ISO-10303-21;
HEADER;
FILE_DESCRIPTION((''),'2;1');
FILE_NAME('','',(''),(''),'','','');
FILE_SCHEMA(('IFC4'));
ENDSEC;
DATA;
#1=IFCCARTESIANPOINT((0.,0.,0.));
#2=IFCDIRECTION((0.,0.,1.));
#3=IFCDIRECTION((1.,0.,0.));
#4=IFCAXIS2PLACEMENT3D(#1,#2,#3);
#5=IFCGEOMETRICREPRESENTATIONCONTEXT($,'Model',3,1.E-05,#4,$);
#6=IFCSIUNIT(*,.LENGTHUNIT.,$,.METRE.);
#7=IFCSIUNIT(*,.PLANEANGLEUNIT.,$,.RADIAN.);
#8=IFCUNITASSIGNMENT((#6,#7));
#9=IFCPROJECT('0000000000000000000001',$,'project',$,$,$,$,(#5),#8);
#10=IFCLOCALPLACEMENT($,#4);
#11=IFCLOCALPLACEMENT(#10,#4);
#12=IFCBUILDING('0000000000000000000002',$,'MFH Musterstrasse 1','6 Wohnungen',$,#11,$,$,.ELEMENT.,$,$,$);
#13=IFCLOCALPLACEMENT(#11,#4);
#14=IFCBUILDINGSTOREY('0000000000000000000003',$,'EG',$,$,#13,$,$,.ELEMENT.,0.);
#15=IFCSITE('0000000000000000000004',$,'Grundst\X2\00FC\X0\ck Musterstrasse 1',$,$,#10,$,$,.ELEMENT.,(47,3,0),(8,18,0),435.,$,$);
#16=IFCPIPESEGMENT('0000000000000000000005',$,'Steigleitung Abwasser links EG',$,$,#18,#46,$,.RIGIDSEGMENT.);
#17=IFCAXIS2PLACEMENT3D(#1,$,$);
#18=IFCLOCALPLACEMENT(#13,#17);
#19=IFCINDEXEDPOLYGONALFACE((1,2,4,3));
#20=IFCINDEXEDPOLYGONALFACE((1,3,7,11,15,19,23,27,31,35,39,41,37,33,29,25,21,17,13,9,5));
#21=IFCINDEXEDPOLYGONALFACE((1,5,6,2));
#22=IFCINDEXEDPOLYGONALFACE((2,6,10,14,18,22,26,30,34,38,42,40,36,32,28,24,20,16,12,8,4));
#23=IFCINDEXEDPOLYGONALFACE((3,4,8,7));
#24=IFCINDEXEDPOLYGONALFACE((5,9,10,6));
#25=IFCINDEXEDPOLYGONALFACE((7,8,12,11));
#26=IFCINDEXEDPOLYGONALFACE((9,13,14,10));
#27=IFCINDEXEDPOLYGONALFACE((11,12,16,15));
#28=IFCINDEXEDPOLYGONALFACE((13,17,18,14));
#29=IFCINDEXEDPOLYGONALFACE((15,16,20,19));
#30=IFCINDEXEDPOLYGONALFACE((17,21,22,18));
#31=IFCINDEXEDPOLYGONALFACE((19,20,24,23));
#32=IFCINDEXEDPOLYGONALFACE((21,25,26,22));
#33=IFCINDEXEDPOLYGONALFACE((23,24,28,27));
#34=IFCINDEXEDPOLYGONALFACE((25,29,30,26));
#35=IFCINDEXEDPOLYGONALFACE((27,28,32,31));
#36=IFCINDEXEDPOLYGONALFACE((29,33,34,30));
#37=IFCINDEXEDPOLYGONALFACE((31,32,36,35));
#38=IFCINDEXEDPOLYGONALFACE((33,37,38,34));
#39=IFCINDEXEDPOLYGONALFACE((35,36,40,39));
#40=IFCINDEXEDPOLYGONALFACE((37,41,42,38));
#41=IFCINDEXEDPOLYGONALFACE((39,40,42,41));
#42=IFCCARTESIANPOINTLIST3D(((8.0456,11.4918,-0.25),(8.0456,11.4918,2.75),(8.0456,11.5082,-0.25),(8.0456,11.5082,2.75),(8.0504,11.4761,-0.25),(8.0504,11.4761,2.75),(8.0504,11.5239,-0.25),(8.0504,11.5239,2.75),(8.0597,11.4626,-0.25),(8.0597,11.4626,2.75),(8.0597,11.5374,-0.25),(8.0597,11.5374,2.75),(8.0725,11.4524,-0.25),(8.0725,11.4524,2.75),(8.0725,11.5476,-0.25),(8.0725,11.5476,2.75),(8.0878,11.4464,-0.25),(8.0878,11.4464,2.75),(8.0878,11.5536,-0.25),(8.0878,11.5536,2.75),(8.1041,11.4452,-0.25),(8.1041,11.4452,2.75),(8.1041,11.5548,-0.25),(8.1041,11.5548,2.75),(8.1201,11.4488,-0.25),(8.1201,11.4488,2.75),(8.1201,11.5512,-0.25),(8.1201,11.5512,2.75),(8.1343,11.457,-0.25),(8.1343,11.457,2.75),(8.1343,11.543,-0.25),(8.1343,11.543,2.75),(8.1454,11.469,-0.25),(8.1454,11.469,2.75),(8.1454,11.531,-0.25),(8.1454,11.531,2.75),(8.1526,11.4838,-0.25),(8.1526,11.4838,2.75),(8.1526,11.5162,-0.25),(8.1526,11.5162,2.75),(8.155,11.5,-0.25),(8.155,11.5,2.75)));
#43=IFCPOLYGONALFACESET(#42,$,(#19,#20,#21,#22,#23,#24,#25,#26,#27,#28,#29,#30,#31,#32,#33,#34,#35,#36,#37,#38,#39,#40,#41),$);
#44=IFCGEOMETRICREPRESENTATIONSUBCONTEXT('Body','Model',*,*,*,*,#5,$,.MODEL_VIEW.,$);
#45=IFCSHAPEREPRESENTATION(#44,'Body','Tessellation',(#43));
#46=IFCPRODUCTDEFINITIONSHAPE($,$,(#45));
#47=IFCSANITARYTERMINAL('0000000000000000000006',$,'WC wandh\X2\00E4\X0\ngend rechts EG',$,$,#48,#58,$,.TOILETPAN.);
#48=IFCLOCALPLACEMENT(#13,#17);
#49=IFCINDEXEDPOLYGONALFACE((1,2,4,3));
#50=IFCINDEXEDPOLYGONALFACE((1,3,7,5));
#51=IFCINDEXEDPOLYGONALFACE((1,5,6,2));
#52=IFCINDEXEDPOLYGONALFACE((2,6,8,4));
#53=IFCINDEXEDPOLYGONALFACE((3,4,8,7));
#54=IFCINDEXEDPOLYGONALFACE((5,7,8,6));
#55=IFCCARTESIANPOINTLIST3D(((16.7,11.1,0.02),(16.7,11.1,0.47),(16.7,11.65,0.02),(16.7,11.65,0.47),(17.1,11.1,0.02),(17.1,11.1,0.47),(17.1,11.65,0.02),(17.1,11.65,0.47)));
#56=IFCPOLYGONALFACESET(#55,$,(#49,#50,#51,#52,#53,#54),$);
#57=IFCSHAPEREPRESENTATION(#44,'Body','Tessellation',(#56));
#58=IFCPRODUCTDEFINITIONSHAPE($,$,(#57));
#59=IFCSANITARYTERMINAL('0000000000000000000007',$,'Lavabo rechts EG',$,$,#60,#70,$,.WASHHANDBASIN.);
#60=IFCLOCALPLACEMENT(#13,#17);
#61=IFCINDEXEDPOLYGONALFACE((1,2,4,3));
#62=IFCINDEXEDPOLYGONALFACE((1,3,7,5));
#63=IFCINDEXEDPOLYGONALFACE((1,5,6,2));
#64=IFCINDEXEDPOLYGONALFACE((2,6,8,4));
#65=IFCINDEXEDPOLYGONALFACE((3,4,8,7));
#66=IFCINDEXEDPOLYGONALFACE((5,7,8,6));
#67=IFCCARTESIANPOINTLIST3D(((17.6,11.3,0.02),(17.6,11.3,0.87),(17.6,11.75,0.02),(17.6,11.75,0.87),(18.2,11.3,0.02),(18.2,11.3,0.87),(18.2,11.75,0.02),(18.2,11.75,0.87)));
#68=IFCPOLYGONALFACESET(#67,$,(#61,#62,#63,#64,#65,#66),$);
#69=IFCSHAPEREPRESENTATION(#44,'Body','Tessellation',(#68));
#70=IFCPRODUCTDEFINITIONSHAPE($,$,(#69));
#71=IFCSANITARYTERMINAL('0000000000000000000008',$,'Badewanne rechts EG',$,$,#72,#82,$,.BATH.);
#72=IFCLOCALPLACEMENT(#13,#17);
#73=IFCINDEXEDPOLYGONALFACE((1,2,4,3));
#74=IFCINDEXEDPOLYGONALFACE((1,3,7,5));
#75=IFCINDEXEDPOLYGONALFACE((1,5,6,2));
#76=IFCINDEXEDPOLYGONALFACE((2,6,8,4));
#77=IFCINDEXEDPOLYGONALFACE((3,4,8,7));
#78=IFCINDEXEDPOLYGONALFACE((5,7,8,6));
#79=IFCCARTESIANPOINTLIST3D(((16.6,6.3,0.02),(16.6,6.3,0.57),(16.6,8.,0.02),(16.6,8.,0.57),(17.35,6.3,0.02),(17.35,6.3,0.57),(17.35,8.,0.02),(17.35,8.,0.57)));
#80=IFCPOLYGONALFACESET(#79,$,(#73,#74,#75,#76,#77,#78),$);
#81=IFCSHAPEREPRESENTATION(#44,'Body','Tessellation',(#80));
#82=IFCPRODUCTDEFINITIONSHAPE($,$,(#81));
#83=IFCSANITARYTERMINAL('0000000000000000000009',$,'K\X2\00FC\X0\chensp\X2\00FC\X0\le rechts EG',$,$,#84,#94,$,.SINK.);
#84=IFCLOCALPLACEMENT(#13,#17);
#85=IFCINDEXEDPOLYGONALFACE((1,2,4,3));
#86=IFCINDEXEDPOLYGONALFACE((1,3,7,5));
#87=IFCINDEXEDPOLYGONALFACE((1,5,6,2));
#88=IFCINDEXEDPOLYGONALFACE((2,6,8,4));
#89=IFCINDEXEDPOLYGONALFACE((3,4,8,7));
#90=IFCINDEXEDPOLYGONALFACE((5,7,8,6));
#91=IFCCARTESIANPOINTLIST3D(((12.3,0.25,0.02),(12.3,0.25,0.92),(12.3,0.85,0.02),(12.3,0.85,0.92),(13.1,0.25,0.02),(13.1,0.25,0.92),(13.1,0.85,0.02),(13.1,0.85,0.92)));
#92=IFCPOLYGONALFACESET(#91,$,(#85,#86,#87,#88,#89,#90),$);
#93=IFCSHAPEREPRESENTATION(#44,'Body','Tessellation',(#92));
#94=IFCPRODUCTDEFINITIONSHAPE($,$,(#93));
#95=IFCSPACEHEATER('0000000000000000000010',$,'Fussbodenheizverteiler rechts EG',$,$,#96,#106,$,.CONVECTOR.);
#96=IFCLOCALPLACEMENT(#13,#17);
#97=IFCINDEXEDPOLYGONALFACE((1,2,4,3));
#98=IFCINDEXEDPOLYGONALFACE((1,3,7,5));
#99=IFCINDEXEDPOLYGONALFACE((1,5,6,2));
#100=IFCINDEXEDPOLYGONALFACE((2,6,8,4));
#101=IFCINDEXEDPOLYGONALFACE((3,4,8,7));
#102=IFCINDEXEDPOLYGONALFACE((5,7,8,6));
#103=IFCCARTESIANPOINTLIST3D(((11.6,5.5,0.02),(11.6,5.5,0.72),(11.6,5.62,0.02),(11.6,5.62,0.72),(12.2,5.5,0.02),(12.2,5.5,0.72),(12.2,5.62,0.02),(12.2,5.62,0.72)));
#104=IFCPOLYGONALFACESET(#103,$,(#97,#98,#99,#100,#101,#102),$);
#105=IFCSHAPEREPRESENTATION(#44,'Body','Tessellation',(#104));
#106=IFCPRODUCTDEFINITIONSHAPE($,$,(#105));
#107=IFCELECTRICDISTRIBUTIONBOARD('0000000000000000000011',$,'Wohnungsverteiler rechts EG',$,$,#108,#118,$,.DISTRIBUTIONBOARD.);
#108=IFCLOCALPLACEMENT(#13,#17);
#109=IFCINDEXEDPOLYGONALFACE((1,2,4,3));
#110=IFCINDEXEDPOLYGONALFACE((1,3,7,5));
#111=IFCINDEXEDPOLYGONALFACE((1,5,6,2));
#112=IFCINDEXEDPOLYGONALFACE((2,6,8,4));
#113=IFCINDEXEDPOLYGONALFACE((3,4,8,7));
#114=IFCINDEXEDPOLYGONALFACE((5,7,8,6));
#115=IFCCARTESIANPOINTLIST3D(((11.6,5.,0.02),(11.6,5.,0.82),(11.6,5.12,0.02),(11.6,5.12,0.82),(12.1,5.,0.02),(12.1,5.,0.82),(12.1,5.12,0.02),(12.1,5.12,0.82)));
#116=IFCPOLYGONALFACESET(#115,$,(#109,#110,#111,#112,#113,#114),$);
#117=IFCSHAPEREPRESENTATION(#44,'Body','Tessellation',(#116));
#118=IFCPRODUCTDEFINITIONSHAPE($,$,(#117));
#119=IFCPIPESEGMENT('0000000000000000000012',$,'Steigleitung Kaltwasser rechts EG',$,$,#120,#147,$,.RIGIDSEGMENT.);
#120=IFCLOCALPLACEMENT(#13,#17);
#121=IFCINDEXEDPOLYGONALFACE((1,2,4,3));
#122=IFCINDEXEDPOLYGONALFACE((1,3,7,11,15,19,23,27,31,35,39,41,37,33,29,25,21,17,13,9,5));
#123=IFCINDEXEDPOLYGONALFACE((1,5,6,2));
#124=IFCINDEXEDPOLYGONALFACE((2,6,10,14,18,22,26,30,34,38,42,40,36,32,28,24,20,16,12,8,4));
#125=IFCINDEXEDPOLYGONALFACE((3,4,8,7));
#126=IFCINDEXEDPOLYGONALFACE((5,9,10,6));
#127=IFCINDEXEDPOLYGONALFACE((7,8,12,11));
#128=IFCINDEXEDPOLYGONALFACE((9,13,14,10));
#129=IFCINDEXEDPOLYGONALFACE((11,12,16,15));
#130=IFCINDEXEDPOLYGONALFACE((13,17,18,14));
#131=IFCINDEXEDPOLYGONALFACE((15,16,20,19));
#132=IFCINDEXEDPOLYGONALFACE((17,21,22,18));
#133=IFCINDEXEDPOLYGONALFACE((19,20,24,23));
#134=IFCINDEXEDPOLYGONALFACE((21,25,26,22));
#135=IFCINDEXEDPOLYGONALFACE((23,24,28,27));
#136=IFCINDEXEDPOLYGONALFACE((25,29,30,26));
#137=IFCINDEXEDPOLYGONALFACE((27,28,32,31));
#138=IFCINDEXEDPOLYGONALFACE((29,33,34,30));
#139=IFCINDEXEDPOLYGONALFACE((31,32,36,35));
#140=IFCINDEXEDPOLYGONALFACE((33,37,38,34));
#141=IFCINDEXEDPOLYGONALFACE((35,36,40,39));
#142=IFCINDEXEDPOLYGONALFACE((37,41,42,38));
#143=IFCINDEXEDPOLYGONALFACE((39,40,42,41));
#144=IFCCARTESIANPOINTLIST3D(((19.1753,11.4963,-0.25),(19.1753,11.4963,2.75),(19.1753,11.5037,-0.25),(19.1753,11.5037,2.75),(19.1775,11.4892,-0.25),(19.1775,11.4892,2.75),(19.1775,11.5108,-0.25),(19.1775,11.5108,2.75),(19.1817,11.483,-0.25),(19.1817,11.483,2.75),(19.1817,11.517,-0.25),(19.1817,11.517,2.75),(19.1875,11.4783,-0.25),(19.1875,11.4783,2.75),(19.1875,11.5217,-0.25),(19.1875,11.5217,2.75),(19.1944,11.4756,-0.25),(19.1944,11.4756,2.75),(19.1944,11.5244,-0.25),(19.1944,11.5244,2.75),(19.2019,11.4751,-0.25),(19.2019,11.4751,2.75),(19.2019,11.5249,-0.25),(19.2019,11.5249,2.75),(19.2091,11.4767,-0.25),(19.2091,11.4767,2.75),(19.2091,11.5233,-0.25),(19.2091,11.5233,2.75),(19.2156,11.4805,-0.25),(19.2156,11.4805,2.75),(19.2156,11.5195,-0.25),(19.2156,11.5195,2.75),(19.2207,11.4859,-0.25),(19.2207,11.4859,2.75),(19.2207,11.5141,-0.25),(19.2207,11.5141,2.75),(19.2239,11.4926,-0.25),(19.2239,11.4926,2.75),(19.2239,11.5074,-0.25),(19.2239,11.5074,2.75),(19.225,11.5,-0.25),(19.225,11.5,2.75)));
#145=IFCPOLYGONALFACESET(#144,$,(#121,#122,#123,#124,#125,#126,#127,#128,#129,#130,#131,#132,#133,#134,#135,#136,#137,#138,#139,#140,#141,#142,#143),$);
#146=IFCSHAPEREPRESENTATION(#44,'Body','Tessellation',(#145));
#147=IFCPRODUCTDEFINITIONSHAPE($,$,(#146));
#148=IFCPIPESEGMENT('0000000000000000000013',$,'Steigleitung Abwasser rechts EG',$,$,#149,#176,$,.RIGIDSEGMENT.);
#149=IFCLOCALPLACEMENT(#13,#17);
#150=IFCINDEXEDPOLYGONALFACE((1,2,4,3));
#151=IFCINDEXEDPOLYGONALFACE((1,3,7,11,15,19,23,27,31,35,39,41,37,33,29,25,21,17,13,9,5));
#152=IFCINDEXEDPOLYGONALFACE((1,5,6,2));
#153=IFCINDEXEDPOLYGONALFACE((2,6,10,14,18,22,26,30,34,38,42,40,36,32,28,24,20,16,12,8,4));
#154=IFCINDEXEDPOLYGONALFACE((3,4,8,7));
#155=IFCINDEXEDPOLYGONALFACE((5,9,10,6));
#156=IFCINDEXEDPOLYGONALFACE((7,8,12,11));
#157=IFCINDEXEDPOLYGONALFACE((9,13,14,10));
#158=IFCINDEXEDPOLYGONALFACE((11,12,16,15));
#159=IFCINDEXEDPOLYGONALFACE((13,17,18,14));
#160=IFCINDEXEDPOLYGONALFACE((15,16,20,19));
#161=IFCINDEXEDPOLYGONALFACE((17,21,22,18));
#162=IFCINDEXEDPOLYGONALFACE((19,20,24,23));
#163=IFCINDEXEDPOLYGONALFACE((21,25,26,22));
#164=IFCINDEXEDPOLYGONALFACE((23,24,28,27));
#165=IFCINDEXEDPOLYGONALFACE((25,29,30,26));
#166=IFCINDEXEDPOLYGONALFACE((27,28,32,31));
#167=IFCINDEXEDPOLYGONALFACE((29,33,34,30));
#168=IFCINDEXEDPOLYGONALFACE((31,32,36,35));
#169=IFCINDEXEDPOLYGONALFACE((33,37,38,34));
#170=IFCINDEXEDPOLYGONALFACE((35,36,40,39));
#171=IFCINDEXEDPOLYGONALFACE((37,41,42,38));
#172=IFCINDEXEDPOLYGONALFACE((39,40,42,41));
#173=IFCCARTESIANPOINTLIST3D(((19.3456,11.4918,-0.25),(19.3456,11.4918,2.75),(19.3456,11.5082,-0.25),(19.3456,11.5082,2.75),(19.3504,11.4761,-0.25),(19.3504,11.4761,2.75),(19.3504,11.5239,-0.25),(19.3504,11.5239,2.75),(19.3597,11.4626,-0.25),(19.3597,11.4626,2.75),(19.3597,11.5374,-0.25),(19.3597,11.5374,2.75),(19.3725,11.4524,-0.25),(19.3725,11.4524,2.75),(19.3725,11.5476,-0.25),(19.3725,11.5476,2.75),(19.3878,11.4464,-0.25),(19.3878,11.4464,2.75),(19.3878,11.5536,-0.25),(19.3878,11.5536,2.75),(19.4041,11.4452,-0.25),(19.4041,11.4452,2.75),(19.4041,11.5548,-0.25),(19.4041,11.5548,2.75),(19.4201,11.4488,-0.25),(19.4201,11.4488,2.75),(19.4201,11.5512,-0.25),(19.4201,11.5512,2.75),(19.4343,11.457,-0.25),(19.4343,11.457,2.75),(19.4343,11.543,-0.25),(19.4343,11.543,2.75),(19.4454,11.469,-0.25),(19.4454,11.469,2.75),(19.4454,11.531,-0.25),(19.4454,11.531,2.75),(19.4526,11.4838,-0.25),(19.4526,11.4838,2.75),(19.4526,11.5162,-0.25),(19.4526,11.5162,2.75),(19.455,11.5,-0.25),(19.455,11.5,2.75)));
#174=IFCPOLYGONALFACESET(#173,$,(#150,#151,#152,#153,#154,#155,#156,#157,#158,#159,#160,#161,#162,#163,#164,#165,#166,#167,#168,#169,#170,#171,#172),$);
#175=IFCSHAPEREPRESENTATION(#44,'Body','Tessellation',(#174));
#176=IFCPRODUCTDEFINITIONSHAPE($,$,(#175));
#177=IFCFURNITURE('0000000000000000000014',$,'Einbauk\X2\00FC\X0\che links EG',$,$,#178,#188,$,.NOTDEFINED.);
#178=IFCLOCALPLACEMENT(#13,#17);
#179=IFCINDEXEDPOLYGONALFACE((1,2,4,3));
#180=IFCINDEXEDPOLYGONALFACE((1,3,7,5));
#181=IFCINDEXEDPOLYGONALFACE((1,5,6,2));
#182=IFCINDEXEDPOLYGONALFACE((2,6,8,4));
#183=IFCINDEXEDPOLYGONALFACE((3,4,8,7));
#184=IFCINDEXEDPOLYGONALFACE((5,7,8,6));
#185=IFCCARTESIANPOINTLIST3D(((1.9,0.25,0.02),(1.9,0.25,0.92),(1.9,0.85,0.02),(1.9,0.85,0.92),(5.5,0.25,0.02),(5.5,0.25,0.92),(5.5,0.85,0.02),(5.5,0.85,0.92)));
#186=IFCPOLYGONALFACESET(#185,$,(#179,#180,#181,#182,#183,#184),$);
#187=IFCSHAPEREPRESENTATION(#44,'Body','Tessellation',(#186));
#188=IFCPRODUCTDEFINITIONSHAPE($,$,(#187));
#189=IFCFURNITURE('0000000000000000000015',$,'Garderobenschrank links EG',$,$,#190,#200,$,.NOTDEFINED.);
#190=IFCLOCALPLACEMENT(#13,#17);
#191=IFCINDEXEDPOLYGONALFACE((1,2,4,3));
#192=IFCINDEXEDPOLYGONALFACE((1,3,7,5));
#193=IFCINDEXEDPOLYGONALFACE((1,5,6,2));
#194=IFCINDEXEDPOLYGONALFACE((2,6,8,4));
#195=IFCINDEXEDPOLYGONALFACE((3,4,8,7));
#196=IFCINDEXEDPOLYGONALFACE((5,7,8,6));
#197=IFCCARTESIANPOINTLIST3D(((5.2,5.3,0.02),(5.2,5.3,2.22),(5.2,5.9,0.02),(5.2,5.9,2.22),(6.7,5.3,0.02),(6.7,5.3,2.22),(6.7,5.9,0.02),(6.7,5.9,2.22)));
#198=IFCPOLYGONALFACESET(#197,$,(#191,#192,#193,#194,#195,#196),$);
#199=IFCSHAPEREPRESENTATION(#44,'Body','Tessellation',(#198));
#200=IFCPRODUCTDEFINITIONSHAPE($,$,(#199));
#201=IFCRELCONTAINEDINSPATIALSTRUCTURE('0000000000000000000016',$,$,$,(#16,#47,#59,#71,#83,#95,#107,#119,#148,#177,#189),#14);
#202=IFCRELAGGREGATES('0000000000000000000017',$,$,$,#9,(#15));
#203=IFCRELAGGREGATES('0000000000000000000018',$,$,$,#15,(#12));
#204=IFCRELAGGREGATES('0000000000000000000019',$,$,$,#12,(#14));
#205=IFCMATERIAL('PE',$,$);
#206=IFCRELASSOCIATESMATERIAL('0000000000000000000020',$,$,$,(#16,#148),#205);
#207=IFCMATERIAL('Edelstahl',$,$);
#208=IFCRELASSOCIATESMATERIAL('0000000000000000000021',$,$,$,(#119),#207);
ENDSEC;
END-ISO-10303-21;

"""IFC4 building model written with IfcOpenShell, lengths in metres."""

from ifc_helpers import new_model, si_unit, frame, frame_2d, origin_with_axes, origin_2d_with_axis, place, context, subcontext, project, spatial, rectangle, circle, extrude, material, element, save


model = new_model("IFC4")

# Units and contexts
model_context = context("Model", 3, precision=1e-05, world=origin_with_axes())
body_context = subcontext(model_context, "Body", "Model", "MODEL_VIEW")
ifc_project = project(units=[si_unit("LENGTHUNIT", "METRE"), si_unit("PLANEANGLEUNIT", "RADIAN")], contexts=[model_context])

# Site, building, storey
site_placement = place(None, origin_with_axes())
site = spatial("IfcSite", under=ifc_project, at=site_placement, Name="Grundstück Musterstrasse 1", CompositionType="ELEMENT", RefLatitude=(47, 3, 0), RefLongitude=(8, 18, 0), RefElevation=435.0)
building_placement = place(site_placement, origin_with_axes())
building = spatial("IfcBuilding", under=site, at=building_placement, Name="MFH Musterstrasse 1", Description="6 Wohnungen", CompositionType="ELEMENT")
storey_placement = place(building_placement, origin_with_axes())
storey = spatial("IfcBuildingStorey", under=building, at=storey_placement, Name="EG", CompositionType="ELEMENT", Elevation=0.0)

# Pipe segment
ifc_material_1 = material(Name="Edelstahl")
ifc_material_2 = material(Name="PE")
pipe_segment_1_placement = place(storey_placement, origin_with_axes())
element("IfcPipeSegment", 1, at=pipe_segment_1_placement, inside=storey, material=ifc_material_2, Name="Steigleitung Abwasser links EG", PredefinedType="RIGIDSEGMENT", context=body_context, shape_type="SweptSolid", body=[
    extrude(circle(Radius=0.055, at=origin_2d_with_axis()), frame((8.1, 11.5, -0.25), z_axis=(0.0, 0.0, 1.0), x_axis=(1.0, 0.0, 0.0)), (0.0, 0.0, 1.0), 3.0),
])

# Sanitary terminals
sanitary_terminal_1_placement = place(storey_placement, origin_with_axes())
element("IfcSanitaryTerminal", 2, at=sanitary_terminal_1_placement, inside=storey, Name="WC wandhängend rechts EG", PredefinedType="TOILETPAN", context=body_context, shape_type="SweptSolid", body=[
    extrude(rectangle(XDim=0.4, YDim=0.55, at=frame_2d((0.2, 0.275), x_axis=(1.0, 0.0))), frame((16.7, 11.1, 0.02), z_axis=(0.0, 0.0, 1.0), x_axis=(1.0, 0.0, 0.0)), (0.0, 0.0, 1.0), 0.45),
])
sanitary_terminal_2_placement = place(storey_placement, origin_with_axes())
element("IfcSanitaryTerminal", 3, at=sanitary_terminal_2_placement, inside=storey, Name="Lavabo rechts EG", PredefinedType="WASHHANDBASIN", context=body_context, shape_type="SweptSolid", body=[
    extrude(rectangle(XDim=0.6, YDim=0.45, at=frame_2d((0.3, 0.225), x_axis=(1.0, 0.0))), frame((17.6, 11.3, 0.02), z_axis=(0.0, 0.0, 1.0), x_axis=(1.0, 0.0, 0.0)), (0.0, 0.0, 1.0), 0.85),
])
sanitary_terminal_3_placement = place(storey_placement, origin_with_axes())
element("IfcSanitaryTerminal", 4, at=sanitary_terminal_3_placement, inside=storey, Name="Badewanne rechts EG", PredefinedType="BATH", context=body_context, shape_type="SweptSolid", body=[
    extrude(rectangle(XDim=0.75, YDim=1.7, at=frame_2d((0.375, 0.85), x_axis=(1.0, 0.0))), frame((16.6, 6.3, 0.02), z_axis=(0.0, 0.0, 1.0), x_axis=(1.0, 0.0, 0.0)), (0.0, 0.0, 1.0), 0.55),
])
sanitary_terminal_4_placement = place(storey_placement, origin_with_axes())
element("IfcSanitaryTerminal", 5, at=sanitary_terminal_4_placement, inside=storey, Name="Küchenspüle rechts EG", PredefinedType="SINK", context=body_context, shape_type="SweptSolid", body=[
    extrude(rectangle(XDim=0.8, YDim=0.6, at=frame_2d((0.4, 0.3), x_axis=(1.0, 0.0))), frame((12.3, 0.25, 0.02), z_axis=(0.0, 0.0, 1.0), x_axis=(1.0, 0.0, 0.0)), (0.0, 0.0, 1.0), 0.9),
])

# Space heater
space_heater_1_placement = place(storey_placement, origin_with_axes())
element("IfcSpaceHeater", 6, at=space_heater_1_placement, inside=storey, Name="Fussbodenheizverteiler rechts EG", PredefinedType="CONVECTOR", context=body_context, shape_type="SweptSolid", body=[
    extrude(rectangle(XDim=0.6, YDim=0.12, at=frame_2d((0.3, 0.06), x_axis=(1.0, 0.0))), frame((11.6, 5.5, 0.02), z_axis=(0.0, 0.0, 1.0), x_axis=(1.0, 0.0, 0.0)), (0.0, 0.0, 1.0), 0.7),
])

# Electric distribution board
electric_distribution_board_1_placement = place(storey_placement, origin_with_axes())
element("IfcElectricDistributionBoard", 7, at=electric_distribution_board_1_placement, inside=storey, Name="Wohnungsverteiler rechts EG", PredefinedType="DISTRIBUTIONBOARD", context=body_context, shape_type="SweptSolid", body=[
    extrude(rectangle(XDim=0.5, YDim=0.12, at=frame_2d((0.25, 0.06), x_axis=(1.0, 0.0))), frame((11.6, 5.0, 0.02), z_axis=(0.0, 0.0, 1.0), x_axis=(1.0, 0.0, 0.0)), (0.0, 0.0, 1.0), 0.8),
])

# Pipe segments
pipe_segment_2_placement = place(storey_placement, origin_with_axes())
element("IfcPipeSegment", 8, at=pipe_segment_2_placement, inside=storey, material=ifc_material_1, Name="Steigleitung Kaltwasser rechts EG", PredefinedType="RIGIDSEGMENT", context=body_context, shape_type="SweptSolid", body=[
    extrude(circle(Radius=0.025, at=origin_2d_with_axis()), frame((19.2, 11.5, -0.25), z_axis=(0.0, 0.0, 1.0), x_axis=(1.0, 0.0, 0.0)), (0.0, 0.0, 1.0), 3.0),
])
pipe_segment_3_placement = place(storey_placement, origin_with_axes())
element("IfcPipeSegment", 9, at=pipe_segment_3_placement, inside=storey, material=ifc_material_2, Name="Steigleitung Abwasser rechts EG", PredefinedType="RIGIDSEGMENT", context=body_context, shape_type="SweptSolid", body=[
    extrude(circle(Radius=0.055, at=origin_2d_with_axis()), frame((19.4, 11.5, -0.25), z_axis=(0.0, 0.0, 1.0), x_axis=(1.0, 0.0, 0.0)), (0.0, 0.0, 1.0), 3.0),
])

# Furniture
furniture_1_placement = place(storey_placement, origin_with_axes())
element("IfcFurniture", 10, at=furniture_1_placement, inside=storey, Name="Einbauküche links EG", PredefinedType="NOTDEFINED", context=body_context, shape_type="SweptSolid", body=[
    extrude(rectangle(XDim=3.6, YDim=0.6, at=frame_2d((1.8, 0.3), x_axis=(1.0, 0.0))), frame((1.9, 0.25, 0.02), z_axis=(0.0, 0.0, 1.0), x_axis=(1.0, 0.0, 0.0)), (0.0, 0.0, 1.0), 0.9),
])
furniture_2_placement = place(storey_placement, origin_with_axes())
element("IfcFurniture", 11, at=furniture_2_placement, inside=storey, Name="Garderobenschrank links EG", PredefinedType="NOTDEFINED", context=body_context, shape_type="SweptSolid", body=[
    extrude(rectangle(XDim=1.5, YDim=0.6, at=frame_2d((0.75, 0.3), x_axis=(1.0, 0.0))), frame((5.2, 5.3, 0.02), z_axis=(0.0, 0.0, 1.0), x_axis=(1.0, 0.0, 0.0)), (0.0, 0.0, 1.0), 2.2),
])

save(model, "model.ifc")
